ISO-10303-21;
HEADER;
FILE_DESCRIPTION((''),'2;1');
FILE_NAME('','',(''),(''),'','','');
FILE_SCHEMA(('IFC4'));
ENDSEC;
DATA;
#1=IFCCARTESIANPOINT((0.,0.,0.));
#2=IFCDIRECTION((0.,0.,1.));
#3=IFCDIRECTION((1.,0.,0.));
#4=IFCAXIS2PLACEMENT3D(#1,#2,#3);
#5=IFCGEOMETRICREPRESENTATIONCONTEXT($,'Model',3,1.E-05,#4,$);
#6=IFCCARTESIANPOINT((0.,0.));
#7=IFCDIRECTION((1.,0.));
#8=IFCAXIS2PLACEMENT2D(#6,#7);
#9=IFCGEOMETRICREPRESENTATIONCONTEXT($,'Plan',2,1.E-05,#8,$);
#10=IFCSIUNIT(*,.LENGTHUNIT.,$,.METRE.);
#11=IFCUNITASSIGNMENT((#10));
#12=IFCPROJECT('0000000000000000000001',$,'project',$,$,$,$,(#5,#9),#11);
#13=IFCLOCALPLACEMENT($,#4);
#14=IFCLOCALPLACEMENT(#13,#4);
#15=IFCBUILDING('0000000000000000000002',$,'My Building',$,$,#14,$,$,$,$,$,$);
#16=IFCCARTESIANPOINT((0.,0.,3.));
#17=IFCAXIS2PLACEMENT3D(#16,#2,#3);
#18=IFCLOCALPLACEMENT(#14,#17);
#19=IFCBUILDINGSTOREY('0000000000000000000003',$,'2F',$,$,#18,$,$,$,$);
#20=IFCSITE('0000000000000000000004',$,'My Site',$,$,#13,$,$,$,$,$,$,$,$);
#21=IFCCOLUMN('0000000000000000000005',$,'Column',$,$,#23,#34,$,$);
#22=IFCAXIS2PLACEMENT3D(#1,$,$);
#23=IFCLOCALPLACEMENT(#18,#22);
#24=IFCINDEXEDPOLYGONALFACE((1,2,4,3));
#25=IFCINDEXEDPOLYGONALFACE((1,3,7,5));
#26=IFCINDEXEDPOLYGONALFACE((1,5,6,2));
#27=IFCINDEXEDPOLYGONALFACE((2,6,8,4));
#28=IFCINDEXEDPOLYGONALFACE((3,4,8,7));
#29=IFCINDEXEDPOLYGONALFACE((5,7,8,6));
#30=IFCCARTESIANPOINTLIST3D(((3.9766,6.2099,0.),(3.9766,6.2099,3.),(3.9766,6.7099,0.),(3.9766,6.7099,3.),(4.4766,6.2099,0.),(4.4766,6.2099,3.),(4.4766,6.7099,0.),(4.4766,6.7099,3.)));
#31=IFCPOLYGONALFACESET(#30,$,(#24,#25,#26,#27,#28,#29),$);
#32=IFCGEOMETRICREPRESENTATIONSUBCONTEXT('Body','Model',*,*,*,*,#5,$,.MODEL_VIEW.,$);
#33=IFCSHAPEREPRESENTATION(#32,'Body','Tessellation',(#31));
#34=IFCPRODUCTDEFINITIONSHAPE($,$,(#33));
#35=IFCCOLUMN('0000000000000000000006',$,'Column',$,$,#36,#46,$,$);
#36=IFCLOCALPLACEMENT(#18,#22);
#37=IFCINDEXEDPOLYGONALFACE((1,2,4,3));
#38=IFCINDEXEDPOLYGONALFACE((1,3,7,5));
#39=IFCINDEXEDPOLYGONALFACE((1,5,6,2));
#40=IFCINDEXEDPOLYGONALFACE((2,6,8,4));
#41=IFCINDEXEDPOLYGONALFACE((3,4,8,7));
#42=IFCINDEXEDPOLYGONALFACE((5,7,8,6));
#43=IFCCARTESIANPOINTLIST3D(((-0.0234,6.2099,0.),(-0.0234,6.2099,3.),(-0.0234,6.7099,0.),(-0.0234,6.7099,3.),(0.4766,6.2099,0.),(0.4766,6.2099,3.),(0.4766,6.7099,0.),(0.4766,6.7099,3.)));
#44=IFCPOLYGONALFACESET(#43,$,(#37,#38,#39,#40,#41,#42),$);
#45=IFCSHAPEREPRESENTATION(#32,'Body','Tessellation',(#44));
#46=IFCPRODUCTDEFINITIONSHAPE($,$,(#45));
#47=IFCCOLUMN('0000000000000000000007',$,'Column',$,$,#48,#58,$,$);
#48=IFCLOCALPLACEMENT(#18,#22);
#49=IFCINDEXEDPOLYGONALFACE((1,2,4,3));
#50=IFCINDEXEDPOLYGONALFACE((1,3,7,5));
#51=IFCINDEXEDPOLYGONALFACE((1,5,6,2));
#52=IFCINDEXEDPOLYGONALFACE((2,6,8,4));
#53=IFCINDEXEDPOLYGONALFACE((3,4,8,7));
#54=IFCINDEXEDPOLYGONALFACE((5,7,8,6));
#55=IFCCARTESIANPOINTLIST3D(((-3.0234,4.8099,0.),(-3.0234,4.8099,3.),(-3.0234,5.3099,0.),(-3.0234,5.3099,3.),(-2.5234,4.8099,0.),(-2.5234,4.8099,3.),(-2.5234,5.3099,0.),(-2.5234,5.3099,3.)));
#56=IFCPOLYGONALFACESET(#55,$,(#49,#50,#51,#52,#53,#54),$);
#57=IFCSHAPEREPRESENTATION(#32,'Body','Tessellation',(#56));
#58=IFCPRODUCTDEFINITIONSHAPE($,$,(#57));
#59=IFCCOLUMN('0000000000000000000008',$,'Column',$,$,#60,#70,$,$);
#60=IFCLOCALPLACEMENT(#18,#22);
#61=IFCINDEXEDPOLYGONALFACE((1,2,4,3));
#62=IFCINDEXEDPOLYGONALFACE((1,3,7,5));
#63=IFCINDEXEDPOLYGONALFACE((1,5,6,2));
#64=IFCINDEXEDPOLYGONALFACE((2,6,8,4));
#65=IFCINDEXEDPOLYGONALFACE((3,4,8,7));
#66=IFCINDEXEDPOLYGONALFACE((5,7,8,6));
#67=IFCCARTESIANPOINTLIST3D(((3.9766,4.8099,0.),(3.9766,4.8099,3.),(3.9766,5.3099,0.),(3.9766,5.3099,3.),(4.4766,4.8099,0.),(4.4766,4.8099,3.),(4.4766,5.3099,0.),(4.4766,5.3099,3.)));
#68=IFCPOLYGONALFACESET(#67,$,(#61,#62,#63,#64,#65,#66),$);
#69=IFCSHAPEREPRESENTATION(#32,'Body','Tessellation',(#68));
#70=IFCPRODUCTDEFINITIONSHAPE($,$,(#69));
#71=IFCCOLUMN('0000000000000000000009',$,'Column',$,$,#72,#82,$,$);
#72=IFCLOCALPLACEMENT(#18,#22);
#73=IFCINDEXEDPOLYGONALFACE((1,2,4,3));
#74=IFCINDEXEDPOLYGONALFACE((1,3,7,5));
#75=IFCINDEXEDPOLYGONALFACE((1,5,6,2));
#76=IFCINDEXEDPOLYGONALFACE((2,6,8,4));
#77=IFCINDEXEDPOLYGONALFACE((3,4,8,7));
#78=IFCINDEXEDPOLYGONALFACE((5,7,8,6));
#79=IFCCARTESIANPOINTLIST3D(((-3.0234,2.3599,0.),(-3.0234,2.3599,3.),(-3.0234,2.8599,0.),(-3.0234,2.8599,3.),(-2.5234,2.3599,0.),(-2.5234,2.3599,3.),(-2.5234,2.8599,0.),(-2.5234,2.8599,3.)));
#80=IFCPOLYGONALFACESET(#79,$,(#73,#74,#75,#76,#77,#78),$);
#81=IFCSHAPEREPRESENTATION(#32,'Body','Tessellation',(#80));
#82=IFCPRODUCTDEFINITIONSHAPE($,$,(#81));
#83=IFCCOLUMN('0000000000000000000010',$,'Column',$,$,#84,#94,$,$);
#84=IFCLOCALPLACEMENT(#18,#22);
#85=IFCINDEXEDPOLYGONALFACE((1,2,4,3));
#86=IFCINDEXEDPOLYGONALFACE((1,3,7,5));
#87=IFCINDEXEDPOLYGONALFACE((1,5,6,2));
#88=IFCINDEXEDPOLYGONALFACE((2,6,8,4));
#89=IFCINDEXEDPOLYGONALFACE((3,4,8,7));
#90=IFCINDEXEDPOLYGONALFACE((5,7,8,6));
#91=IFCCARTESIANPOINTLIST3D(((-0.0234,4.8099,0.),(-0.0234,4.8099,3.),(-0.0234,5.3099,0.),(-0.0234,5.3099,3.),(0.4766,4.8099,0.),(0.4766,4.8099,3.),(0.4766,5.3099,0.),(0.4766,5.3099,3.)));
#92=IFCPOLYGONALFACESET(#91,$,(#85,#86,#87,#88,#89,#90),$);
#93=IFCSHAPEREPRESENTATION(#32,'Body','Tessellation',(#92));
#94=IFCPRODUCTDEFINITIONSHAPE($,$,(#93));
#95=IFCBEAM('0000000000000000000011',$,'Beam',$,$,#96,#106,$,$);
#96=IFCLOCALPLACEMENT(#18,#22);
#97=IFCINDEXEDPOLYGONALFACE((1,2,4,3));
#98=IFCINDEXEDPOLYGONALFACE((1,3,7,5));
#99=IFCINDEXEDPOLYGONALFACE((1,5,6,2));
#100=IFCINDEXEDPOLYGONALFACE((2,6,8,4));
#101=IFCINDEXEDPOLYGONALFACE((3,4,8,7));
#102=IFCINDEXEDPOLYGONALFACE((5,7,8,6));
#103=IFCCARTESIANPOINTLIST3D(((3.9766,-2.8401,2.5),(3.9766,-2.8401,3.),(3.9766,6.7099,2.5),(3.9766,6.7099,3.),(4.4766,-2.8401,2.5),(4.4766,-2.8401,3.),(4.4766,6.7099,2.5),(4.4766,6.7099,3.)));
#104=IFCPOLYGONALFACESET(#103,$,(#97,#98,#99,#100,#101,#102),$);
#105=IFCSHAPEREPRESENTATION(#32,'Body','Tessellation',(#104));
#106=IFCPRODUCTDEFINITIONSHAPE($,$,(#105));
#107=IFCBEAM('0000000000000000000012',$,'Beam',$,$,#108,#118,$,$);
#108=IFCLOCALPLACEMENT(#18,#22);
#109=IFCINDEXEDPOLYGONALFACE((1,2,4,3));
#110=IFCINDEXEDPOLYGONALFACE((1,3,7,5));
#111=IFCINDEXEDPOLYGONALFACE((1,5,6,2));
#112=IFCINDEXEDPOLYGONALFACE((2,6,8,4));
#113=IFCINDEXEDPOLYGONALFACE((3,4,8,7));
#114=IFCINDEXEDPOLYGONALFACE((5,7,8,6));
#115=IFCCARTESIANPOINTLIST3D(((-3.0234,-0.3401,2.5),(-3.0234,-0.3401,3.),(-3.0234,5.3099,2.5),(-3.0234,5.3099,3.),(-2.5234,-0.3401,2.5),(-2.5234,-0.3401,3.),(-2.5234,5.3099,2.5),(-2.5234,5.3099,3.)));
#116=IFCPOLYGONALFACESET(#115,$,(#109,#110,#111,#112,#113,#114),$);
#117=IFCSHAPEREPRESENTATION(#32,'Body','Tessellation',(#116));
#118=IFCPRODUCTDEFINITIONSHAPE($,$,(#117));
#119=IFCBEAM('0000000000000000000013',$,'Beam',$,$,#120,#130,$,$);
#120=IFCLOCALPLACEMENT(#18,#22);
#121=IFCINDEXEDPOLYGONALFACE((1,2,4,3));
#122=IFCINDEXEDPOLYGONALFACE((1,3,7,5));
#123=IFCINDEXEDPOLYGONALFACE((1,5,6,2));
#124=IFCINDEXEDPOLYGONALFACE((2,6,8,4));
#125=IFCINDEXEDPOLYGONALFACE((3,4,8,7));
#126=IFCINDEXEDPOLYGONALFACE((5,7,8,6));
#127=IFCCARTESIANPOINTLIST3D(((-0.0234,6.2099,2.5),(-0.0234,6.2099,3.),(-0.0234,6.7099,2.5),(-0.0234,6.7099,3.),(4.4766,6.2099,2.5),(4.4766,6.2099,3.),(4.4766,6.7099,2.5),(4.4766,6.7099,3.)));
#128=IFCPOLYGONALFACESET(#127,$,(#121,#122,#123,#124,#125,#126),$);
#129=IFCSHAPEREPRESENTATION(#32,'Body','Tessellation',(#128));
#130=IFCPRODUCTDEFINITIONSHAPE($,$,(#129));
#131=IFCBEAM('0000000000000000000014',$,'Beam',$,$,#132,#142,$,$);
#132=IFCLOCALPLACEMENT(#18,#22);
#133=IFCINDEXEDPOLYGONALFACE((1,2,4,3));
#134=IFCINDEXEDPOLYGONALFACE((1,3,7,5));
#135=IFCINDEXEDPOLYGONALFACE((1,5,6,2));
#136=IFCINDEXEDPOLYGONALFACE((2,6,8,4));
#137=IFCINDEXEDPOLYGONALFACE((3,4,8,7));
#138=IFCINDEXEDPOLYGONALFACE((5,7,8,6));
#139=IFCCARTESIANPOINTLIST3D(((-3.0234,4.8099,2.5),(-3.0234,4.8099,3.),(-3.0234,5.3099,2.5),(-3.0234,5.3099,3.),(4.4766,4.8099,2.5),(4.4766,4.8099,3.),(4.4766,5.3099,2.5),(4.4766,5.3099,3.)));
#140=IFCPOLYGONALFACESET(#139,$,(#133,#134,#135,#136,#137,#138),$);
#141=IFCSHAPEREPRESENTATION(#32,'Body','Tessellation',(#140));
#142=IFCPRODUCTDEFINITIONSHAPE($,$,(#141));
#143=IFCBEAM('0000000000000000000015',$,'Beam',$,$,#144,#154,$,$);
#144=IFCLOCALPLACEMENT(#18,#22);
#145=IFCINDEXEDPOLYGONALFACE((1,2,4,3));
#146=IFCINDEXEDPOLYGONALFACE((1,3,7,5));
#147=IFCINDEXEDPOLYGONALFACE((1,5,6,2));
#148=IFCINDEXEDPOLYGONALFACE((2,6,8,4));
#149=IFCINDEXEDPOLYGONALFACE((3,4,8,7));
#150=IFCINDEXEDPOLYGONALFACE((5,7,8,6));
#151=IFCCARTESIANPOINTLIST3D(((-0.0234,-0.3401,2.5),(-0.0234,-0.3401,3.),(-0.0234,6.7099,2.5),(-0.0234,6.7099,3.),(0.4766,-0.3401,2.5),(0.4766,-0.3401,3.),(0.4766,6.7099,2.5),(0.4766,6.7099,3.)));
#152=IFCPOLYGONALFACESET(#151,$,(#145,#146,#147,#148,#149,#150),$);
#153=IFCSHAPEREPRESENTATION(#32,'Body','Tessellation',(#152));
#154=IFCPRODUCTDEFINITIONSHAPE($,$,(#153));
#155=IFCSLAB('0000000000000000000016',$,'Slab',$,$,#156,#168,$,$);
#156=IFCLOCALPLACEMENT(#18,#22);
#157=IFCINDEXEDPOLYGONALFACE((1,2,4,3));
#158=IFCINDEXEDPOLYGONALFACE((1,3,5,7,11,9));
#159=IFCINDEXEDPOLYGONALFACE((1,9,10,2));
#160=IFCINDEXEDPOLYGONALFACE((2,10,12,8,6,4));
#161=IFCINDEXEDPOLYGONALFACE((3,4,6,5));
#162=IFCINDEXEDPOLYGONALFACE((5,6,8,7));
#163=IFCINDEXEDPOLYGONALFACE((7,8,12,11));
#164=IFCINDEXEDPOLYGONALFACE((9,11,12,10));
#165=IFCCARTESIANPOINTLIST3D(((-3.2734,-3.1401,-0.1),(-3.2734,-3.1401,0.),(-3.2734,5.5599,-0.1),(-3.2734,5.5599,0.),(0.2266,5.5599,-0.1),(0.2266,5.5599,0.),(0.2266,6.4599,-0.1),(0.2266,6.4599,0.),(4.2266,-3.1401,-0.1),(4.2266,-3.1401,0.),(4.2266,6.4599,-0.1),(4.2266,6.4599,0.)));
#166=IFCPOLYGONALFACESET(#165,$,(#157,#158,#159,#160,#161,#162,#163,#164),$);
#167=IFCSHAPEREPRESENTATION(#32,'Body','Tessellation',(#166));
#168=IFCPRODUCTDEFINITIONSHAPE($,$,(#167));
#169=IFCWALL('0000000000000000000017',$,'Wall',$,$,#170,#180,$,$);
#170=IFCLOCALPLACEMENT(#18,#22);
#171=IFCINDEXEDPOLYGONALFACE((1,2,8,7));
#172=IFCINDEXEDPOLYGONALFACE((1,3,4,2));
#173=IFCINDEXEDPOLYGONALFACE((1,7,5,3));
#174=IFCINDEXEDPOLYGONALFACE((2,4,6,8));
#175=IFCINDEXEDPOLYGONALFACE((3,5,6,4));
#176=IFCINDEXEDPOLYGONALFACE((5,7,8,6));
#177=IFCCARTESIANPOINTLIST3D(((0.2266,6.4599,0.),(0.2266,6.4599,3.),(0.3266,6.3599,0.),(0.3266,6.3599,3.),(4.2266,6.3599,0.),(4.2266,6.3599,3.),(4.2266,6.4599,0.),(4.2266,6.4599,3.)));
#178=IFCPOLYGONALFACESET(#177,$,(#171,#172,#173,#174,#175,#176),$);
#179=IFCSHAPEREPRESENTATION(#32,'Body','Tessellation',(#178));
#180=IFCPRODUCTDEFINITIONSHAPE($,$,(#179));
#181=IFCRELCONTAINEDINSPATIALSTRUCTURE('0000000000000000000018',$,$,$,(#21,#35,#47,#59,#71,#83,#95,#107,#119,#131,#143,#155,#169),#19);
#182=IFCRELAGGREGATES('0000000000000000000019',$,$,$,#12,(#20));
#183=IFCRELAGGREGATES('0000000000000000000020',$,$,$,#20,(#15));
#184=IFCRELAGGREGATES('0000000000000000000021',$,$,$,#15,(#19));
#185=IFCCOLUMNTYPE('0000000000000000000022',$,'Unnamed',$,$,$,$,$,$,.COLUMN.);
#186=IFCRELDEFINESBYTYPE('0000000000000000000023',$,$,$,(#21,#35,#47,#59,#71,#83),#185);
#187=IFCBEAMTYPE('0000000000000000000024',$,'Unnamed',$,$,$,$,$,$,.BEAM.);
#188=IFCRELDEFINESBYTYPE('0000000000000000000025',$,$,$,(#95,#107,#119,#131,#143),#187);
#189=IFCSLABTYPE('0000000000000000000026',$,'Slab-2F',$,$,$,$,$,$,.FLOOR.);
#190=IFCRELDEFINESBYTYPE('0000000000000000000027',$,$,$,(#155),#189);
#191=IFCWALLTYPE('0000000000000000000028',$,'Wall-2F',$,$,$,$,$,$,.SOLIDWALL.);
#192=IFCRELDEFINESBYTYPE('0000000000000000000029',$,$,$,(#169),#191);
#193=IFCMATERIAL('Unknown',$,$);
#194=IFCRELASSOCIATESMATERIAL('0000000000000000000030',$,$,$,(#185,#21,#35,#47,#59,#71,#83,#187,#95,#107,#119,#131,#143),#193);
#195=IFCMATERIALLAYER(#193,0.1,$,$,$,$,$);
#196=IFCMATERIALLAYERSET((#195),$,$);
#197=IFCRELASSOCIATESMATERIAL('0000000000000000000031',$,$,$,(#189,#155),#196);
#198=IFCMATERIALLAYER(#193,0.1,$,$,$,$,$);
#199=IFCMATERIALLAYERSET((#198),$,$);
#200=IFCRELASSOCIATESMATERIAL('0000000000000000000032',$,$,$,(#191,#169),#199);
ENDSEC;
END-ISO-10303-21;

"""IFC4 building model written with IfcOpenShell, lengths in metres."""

from ifc_helpers import new_model, si_unit, frame, origin_with_axes, origin_2d_with_axis, place, context, subcontext, project, spatial, line, indexed_curve, rectangle, outline, extrude, material, layer, layer_set, layer_usage, material_profile, profile_set, profile_usage, type_object, element, save


model = new_model("IFC4")

# Units and contexts
model_context = context("Model", 3, precision=1e-05, world=origin_with_axes())
plan_context = context("Plan", 2, precision=1e-05, world=origin_2d_with_axis())
body_context_1 = subcontext(model_context, "Body", "Model", "MODEL_VIEW")
ifc_project = project(units=[si_unit("LENGTHUNIT", "METRE")], contexts=[model_context, plan_context])

# Site, building, storey
site_placement = place(None, origin_with_axes())
site = spatial("IfcSite", under=ifc_project, at=site_placement, Name="My Site")
building_placement = place(site_placement, origin_with_axes())
building = spatial("IfcBuilding", under=site, at=building_placement, Name="My Building")
storey_placement = place(building_placement, frame((0.0, 0.0, 3.0), z_axis=(0.0, 0.0, 1.0), x_axis=(1.0, 0.0, 0.0)))
storey = spatial("IfcBuildingStorey", under=building, at=storey_placement, Name="2F")

# Columns
ifc_material = material(Name="Unknown")
ifc_material_profile_1 = material_profile(ifc_material, rectangle(XDim=0.5, YDim=0.5))
ifc_profile_set_1 = profile_set([ifc_material_profile_1])
ifc_profile_usage_1 = profile_usage(ifc_profile_set_1, cardinal=5)
column_type = type_object("IfcColumnType", Name="Unnamed", PredefinedType="COLUMN", material=ifc_profile_set_1)
column_1_placement = place(storey_placement, frame((4.2266, 6.4599, 0.0), z_axis=(0.0, 0.0, 1.0), x_axis=(1.0, 0.0, 0.0)))
element("IfcColumn", 1, at=column_1_placement, inside=storey, type_object=column_type, material=ifc_profile_usage_1, Name="Column", context=body_context_1, shape_type="SweptSolid", body=[
    extrude(rectangle(XDim=0.5, YDim=0.5), origin_with_axes(), (0.0, 0.0, 1.0), 3.0),
])
ifc_profile_usage_2 = profile_usage(ifc_profile_set_1, cardinal=5)
column_2_placement = place(storey_placement, frame((0.2266, 6.4599, 0.0), z_axis=(0.0, 0.0, 1.0), x_axis=(1.0, 0.0, 0.0)))
element("IfcColumn", 2, at=column_2_placement, inside=storey, type_object=column_type, material=ifc_profile_usage_2, Name="Column", context=body_context_1, shape_type="SweptSolid", body=[
    extrude(rectangle(XDim=0.5, YDim=0.5), origin_with_axes(), (0.0, 0.0, 1.0), 3.0),
])
ifc_profile_usage_3 = profile_usage(ifc_profile_set_1, cardinal=5)
column_3_placement = place(storey_placement, frame((-2.7734, 5.0599, 0.0), z_axis=(0.0, 0.0, 1.0), x_axis=(1.0, 0.0, 0.0)))
element("IfcColumn", 3, at=column_3_placement, inside=storey, type_object=column_type, material=ifc_profile_usage_3, Name="Column", context=body_context_1, shape_type="SweptSolid", body=[
    extrude(rectangle(XDim=0.5, YDim=0.5), origin_with_axes(), (0.0, 0.0, 1.0), 3.0),
])
ifc_profile_usage_4 = profile_usage(ifc_profile_set_1, cardinal=5)
column_4_placement = place(storey_placement, frame((4.2266, 5.0599, 0.0), z_axis=(0.0, 0.0, 1.0), x_axis=(1.0, 0.0, 0.0)))
element("IfcColumn", 4, at=column_4_placement, inside=storey, type_object=column_type, material=ifc_profile_usage_4, Name="Column", context=body_context_1, shape_type="SweptSolid", body=[
    extrude(rectangle(XDim=0.5, YDim=0.5), origin_with_axes(), (0.0, 0.0, 1.0), 3.0),
])
ifc_profile_usage_5 = profile_usage(ifc_profile_set_1, cardinal=5)
column_5_placement = place(storey_placement, frame((-2.7734, 2.6099, 0.0), z_axis=(0.0, 0.0, 1.0), x_axis=(1.0, 0.0, 0.0)))
element("IfcColumn", 5, at=column_5_placement, inside=storey, type_object=column_type, material=ifc_profile_usage_5, Name="Column", context=body_context_1, shape_type="SweptSolid", body=[
    extrude(rectangle(XDim=0.5, YDim=0.5), origin_with_axes(), (0.0, 0.0, 1.0), 3.0),
])
ifc_profile_usage_6 = profile_usage(ifc_profile_set_1, cardinal=5)
column_6_placement = place(storey_placement, frame((0.2266, 5.0599, 0.0), z_axis=(0.0, 0.0, 1.0), x_axis=(1.0, 0.0, 0.0)))
element("IfcColumn", 6, at=column_6_placement, inside=storey, type_object=column_type, material=ifc_profile_usage_6, Name="Column", context=body_context_1, shape_type="SweptSolid", body=[
    extrude(rectangle(XDim=0.5, YDim=0.5), origin_with_axes(), (0.0, 0.0, 1.0), 3.0),
])

# Beams
ifc_material_profile_2 = material_profile(ifc_material, rectangle(XDim=0.5, YDim=0.5))
ifc_profile_set_2 = profile_set([ifc_material_profile_2])
ifc_profile_usage_7 = profile_usage(ifc_profile_set_2, cardinal=7)
beam_type = type_object("IfcBeamType", Name="Unnamed", PredefinedType="BEAM", material=ifc_profile_set_2)
beam_1_placement = place(storey_placement, frame((4.4766, 6.7099, 3.0), z_axis=(0.0, -1.0, 0.0), x_axis=(1.0, 0.0, 0.0)))
element("IfcBeam", 7, at=beam_1_placement, inside=storey, type_object=beam_type, material=ifc_profile_usage_7, Name="Beam", context=body_context_1, shape_type="SweptSolid", body=[
    extrude(rectangle(XDim=0.5, YDim=0.5), frame((-0.25, -0.25, 0.0), z_axis=(0.0, 0.0, 1.0), x_axis=(1.0, 0.0, 0.0)), (0.0, 0.0, 1.0), 9.55),
])
ifc_profile_usage_8 = profile_usage(ifc_profile_set_2, cardinal=7)
beam_2_placement = place(storey_placement, frame((-2.5234, 5.3099, 3.0), z_axis=(0.0, -1.0, 0.0), x_axis=(1.0, 0.0, 0.0)))
element("IfcBeam", 8, at=beam_2_placement, inside=storey, type_object=beam_type, material=ifc_profile_usage_8, Name="Beam", context=body_context_1, shape_type="SweptSolid", body=[
    extrude(rectangle(XDim=0.5, YDim=0.5), frame((-0.25, -0.25, 0.0), z_axis=(0.0, 0.0, 1.0), x_axis=(1.0, 0.0, 0.0)), (0.0, 0.0, 1.0), 5.65),
])
ifc_profile_usage_9 = profile_usage(ifc_profile_set_2, cardinal=7)
beam_3_placement = place(storey_placement, frame((4.4766, 6.2099, 3.0), z_axis=(-1.0, 0.0, 0.0), x_axis=(0.0, -1.0, 0.0)))
element("IfcBeam", 9, at=beam_3_placement, inside=storey, type_object=beam_type, material=ifc_profile_usage_9, Name="Beam", context=body_context_1, shape_type="SweptSolid", body=[
    extrude(rectangle(XDim=0.5, YDim=0.5), frame((-0.25, -0.25, 0.0), z_axis=(0.0, 0.0, 1.0), x_axis=(1.0, 0.0, 0.0)), (0.0, 0.0, 1.0), 4.5),
])
ifc_profile_usage_10 = profile_usage(ifc_profile_set_2, cardinal=7)
beam_4_placement = place(storey_placement, frame((4.4766, 4.8099, 3.0), z_axis=(-1.0, 0.0, 0.0), x_axis=(0.0, -1.0, 0.0)))
element("IfcBeam", 10, at=beam_4_placement, inside=storey, type_object=beam_type, material=ifc_profile_usage_10, Name="Beam", context=body_context_1, shape_type="SweptSolid", body=[
    extrude(rectangle(XDim=0.5, YDim=0.5), frame((-0.25, -0.25, 0.0), z_axis=(0.0, 0.0, 1.0), x_axis=(1.0, 0.0, 0.0)), (0.0, 0.0, 1.0), 7.5),
])
ifc_profile_usage_11 = profile_usage(ifc_profile_set_2, cardinal=7)
beam_5_placement = place(storey_placement, frame((0.4766, 6.7099, 3.0), z_axis=(0.0, -1.0, 0.0), x_axis=(1.0, 0.0, 0.0)))
element("IfcBeam", 11, at=beam_5_placement, inside=storey, type_object=beam_type, material=ifc_profile_usage_11, Name="Beam", context=body_context_1, shape_type="SweptSolid", body=[
    extrude(rectangle(XDim=0.5, YDim=0.5), frame((-0.25, -0.25, 0.0), z_axis=(0.0, 0.0, 1.0), x_axis=(1.0, 0.0, 0.0)), (0.0, 0.0, 1.0), 7.05),
])

# Slab
ifc_layer_1 = layer(ifc_material, 0.1)
ifc_layer_set_1 = layer_set([ifc_layer_1])
ifc_layer_usage_1 = layer_usage(ifc_layer_set_1, "AXIS3", "POSITIVE", -0.1)
slab_type = type_object("IfcSlabType", Name="Slab-2F", PredefinedType="FLOOR", material=ifc_layer_set_1)
slab_placement = place(storey_placement, frame((4.2266, 6.4599, 0.0), z_axis=(0.0, 0.0, 1.0), x_axis=(1.0, 0.0, 0.0)))
element("IfcSlab", 12, at=slab_placement, inside=storey, type_object=slab_type, material=ifc_layer_usage_1, Name="Slab", context=body_context_1, shape_type="SweptSolid", body=[
    extrude(outline(indexed_curve([(0.0, 0.0), (-4.0, 0.0), (-4.0, -0.9), (-7.5, -0.9), (-7.5, -9.6), (0.0, -9.6), (0.0, 0.0)])), frame((0.0, 0.0, -0.1), z_axis=(0.0, 0.0, 1.0), x_axis=(1.0, 0.0, 0.0)), (0.0, 0.0, 1.0), 0.1),
])

# Wall
ifc_layer_2 = layer(ifc_material, 0.1)
ifc_layer_set_2 = layer_set([ifc_layer_2])
ifc_layer_usage_2 = layer_usage(ifc_layer_set_2, "AXIS2", "POSITIVE", 0.0)
wall_type_1 = type_object("IfcWallType", Name="Wall-2F", PredefinedType="SOLIDWALL", material=ifc_layer_set_2)
wall_1_placement = place(storey_placement, frame((4.2266, 6.4599, 0.0), z_axis=(0.0, 0.0, 1.0), x_axis=(-1.0, 0.0, 0.0)))
element("IfcWall", 13, at=wall_1_placement, inside=storey, type_object=wall_type_1, material=ifc_layer_usage_2, Name="Wall", context=body_context_1, shape_type="SweptSolid", body=[
    extrude(outline(indexed_curve([(0.0, 0.0), (0.0, 0.1), (3.9, 0.1), (4.0, 0.0)], segments=[line(1, 2, 3, 4, 1)])), origin_with_axes(), (0.0, 0.0, 1.0), 3.0),
])

save(model, "model.ifc")
